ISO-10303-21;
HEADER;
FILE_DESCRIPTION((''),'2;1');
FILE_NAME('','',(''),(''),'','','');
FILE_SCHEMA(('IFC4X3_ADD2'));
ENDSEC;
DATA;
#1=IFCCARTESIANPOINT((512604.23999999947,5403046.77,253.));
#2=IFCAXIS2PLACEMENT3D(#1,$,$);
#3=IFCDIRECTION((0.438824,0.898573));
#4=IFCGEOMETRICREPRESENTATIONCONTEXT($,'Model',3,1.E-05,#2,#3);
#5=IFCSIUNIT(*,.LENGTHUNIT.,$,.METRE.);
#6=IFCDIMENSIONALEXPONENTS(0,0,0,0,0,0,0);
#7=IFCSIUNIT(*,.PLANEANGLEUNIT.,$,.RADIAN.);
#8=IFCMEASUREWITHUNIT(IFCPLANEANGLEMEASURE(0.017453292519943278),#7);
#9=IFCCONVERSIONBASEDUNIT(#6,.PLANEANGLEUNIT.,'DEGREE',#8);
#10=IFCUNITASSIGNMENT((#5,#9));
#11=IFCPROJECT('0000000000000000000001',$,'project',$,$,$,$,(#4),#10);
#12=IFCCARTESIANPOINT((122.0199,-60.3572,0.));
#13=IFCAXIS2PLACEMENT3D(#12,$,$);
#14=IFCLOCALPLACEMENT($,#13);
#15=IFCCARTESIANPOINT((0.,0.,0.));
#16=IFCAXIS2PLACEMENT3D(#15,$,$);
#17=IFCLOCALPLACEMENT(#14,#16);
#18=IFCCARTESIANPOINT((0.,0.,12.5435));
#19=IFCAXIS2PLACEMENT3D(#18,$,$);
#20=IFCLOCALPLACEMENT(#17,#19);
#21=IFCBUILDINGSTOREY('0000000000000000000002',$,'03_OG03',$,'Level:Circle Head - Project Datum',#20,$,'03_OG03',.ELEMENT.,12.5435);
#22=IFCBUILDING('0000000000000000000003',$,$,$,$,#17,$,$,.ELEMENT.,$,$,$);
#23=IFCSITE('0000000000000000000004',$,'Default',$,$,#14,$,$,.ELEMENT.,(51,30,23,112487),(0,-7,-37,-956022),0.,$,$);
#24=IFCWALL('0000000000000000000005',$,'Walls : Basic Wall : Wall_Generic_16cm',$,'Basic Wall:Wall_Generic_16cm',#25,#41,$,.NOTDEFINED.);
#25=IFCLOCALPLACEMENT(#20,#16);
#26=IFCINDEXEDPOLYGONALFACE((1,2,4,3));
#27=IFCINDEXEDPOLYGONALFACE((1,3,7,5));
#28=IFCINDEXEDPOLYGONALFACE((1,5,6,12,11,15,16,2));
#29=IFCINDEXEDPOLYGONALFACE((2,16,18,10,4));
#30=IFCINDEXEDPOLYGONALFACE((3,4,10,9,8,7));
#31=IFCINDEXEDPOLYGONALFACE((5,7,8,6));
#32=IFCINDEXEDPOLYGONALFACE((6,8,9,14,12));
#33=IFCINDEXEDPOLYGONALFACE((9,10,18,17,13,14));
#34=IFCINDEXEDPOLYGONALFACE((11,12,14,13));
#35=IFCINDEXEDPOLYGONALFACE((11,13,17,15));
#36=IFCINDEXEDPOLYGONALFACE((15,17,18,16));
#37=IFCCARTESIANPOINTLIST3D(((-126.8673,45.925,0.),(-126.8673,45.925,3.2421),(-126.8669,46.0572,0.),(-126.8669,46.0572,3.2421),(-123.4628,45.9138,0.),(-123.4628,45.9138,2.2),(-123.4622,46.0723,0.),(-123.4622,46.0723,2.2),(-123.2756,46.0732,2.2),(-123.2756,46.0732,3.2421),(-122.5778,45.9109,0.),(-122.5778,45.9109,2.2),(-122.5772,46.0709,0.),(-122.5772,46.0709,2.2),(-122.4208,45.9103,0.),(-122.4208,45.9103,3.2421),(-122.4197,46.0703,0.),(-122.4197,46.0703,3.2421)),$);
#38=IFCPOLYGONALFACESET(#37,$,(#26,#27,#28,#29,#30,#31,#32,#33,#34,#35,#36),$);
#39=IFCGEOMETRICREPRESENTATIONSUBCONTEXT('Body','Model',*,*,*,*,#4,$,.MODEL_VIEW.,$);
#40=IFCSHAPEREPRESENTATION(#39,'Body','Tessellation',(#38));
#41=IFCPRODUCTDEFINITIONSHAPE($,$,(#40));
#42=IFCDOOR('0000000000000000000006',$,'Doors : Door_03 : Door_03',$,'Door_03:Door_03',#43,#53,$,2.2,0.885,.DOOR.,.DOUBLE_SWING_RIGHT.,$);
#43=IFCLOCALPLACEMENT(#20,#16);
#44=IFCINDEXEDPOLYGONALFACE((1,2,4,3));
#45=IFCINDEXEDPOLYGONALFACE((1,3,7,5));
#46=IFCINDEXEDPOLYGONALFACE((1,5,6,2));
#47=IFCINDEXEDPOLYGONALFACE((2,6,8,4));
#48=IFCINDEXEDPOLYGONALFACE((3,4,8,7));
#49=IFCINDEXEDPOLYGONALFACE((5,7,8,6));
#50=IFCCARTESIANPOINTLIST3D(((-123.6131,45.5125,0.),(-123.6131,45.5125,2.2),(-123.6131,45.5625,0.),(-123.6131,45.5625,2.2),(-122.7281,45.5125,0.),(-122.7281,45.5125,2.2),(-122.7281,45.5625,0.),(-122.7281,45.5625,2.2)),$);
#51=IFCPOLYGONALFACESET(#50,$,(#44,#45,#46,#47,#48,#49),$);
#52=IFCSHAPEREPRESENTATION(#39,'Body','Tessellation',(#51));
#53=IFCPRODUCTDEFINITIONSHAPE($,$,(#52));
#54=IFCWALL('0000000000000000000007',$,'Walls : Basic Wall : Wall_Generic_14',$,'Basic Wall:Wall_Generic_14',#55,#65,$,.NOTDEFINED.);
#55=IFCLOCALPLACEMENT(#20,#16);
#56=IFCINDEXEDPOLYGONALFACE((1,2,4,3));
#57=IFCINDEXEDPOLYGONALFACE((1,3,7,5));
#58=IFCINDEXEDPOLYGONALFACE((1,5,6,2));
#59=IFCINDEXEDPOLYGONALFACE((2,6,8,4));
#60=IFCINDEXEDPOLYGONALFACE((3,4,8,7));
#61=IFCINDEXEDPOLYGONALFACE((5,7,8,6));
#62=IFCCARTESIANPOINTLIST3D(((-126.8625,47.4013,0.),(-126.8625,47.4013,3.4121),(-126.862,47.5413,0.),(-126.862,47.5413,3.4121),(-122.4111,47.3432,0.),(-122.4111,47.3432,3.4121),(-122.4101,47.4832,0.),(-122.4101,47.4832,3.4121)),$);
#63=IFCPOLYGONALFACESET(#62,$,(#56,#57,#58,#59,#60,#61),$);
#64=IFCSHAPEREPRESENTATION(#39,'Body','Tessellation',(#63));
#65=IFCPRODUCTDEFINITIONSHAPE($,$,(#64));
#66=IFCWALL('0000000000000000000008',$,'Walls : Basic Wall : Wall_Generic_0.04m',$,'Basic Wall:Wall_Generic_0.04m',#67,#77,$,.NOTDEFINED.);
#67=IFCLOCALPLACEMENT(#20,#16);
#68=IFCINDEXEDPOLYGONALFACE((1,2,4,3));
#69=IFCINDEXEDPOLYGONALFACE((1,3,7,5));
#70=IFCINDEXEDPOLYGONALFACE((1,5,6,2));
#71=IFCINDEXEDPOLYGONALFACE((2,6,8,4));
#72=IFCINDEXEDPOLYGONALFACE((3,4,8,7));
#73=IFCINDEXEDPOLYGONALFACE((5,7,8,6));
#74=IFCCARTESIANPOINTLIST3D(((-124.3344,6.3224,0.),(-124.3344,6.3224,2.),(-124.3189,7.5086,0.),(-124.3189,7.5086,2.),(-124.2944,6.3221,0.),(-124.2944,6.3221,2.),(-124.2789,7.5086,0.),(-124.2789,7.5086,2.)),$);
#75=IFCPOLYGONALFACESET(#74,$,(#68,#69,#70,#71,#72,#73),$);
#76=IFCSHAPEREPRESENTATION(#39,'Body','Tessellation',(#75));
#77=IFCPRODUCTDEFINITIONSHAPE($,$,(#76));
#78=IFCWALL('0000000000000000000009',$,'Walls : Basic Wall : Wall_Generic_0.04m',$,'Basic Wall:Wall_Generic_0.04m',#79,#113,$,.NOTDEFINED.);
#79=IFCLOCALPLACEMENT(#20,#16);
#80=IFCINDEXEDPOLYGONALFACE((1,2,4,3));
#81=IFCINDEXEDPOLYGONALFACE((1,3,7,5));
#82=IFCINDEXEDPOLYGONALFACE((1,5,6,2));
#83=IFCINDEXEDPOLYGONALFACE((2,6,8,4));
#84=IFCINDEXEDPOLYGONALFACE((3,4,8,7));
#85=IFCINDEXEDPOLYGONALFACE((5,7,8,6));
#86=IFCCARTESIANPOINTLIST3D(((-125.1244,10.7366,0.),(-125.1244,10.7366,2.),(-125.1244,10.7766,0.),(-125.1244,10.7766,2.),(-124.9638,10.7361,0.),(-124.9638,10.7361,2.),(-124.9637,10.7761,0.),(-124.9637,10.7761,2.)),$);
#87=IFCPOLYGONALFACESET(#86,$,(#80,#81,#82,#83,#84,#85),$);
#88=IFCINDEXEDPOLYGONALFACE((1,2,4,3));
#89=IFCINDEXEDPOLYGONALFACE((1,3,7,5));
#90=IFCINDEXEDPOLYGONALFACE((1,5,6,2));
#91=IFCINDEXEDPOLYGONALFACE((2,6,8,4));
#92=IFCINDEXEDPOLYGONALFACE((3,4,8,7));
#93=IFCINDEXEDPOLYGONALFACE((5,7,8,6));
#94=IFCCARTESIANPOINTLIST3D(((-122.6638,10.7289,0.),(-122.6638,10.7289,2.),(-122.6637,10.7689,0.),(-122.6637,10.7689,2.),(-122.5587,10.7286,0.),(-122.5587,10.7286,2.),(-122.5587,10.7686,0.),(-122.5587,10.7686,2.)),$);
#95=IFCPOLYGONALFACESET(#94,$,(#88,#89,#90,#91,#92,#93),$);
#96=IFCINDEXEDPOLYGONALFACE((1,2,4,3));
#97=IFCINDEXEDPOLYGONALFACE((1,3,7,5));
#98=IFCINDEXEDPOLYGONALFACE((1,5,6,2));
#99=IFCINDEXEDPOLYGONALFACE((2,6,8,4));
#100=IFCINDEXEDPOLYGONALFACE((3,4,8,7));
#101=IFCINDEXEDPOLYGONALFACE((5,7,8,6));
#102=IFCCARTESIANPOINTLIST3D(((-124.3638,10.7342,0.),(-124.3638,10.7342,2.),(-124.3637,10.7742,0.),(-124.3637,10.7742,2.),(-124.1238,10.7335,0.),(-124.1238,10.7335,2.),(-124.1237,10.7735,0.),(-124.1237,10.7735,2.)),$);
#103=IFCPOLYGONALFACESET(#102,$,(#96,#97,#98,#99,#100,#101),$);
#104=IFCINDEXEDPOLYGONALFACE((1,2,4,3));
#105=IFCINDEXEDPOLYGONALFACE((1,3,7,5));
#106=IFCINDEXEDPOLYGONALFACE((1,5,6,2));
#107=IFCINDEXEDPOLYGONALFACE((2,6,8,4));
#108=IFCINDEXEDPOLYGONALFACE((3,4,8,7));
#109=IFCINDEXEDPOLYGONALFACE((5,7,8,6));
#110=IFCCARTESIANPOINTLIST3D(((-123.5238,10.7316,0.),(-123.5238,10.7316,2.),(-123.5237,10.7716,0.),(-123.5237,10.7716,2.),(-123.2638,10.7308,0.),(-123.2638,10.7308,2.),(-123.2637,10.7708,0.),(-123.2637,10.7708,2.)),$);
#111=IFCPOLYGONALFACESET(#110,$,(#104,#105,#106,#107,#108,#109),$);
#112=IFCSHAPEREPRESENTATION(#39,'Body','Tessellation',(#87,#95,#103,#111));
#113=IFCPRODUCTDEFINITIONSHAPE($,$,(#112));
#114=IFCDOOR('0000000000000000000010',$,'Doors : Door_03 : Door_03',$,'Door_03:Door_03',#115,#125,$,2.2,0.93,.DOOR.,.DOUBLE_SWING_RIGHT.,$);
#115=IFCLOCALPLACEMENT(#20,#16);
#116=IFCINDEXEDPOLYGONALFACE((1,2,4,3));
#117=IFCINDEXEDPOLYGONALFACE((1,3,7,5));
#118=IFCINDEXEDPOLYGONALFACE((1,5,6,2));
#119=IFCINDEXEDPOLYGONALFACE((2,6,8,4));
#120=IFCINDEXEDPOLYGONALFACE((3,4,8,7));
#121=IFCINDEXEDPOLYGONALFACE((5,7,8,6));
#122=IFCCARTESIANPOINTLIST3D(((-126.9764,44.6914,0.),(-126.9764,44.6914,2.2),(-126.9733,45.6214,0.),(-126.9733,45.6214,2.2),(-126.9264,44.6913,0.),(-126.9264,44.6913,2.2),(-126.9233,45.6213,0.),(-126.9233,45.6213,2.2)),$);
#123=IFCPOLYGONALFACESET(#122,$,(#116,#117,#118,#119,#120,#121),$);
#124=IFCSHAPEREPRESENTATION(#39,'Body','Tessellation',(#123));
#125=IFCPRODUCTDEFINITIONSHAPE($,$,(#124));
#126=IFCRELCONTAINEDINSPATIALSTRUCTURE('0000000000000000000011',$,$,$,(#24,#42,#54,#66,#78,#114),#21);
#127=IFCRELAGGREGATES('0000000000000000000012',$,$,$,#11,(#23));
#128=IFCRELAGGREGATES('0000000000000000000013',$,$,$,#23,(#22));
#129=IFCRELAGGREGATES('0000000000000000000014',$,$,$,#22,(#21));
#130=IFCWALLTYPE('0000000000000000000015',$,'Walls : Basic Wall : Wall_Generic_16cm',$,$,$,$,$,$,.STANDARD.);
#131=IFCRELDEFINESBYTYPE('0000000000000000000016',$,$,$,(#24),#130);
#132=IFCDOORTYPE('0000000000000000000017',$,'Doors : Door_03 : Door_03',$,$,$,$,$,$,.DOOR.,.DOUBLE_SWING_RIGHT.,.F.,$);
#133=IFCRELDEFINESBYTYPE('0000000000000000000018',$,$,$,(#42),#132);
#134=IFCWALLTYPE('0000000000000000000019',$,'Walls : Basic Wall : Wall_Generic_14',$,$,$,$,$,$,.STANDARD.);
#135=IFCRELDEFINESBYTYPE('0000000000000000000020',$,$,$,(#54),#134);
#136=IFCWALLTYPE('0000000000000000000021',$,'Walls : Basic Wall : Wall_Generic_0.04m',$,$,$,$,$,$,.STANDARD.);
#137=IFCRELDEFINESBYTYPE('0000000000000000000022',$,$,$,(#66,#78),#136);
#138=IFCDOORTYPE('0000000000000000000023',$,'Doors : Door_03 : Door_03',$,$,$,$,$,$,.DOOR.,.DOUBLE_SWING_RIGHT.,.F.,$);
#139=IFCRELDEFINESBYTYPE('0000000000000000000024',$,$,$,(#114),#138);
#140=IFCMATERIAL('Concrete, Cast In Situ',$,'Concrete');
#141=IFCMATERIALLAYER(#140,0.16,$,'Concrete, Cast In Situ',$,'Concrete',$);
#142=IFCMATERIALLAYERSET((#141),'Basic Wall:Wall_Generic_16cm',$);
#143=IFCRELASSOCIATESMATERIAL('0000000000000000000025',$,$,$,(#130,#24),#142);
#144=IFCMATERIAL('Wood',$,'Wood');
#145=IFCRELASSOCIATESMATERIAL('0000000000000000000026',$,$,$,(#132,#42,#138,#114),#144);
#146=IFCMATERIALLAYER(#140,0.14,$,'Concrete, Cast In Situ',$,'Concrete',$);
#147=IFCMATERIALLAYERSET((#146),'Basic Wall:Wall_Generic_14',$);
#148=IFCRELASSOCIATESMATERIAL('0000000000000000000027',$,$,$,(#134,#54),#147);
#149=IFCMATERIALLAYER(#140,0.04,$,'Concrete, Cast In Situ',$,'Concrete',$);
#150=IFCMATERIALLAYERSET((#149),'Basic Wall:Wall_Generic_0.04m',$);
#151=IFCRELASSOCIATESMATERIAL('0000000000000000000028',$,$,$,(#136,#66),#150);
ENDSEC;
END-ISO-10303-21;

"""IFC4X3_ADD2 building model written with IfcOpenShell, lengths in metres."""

from ifc_helpers import new_model, entity, si_unit, converted_unit, direction, frame, frame_2d, origin, place, context, subcontext, project, spatial, polyline, rectangle, outline, extrude, clip, bounded_halfspace, source, transform, mapped, material, layer, layer_set, type_object, type_shapes, element, fill, save


model = new_model("IFC4X3_ADD2")

# Units and contexts
model_context = context("Model", 3, precision=1e-05, world=frame((512604.23999999947, 5403046.77, 253.0)), true_north=direction((0.438824, 0.898573)))
body_context = subcontext(model_context, "Body", "Model", "MODEL_VIEW")
ifc_project = project(units=[si_unit("LENGTHUNIT", "METRE"), converted_unit("PLANEANGLEUNIT", "DEGREE", entity("IfcPlaneAngleMeasure", 0.017453292519943278), si_unit("PLANEANGLEUNIT", "RADIAN"), dimensions=[0, 0, 0, 0, 0, 0, 0])], contexts=[model_context])

# Site, building, storey
site_placement = place(None, frame((122.0199, -60.3572, 0.0)))
site = spatial("IfcSite", under=ifc_project, at=site_placement, Name="Default", CompositionType="ELEMENT", RefLatitude=(51, 30, 23, 112487), RefLongitude=(0, -7, -37, -956022), RefElevation=0.0)
building_placement = place(site_placement, origin())
building = spatial("IfcBuilding", under=site, at=building_placement, CompositionType="ELEMENT")
storey_placement = place(building_placement, frame((0.0, 0.0, 12.5435)))
storey = spatial("IfcBuildingStorey", under=building, at=storey_placement, Name="03_OG03", ObjectType="Level:Circle Head - Project Datum", LongName="03_OG03", CompositionType="ELEMENT", Elevation=12.5435)

# Shared definitions
ifc_material_1 = material(Name="Concrete, Cast In Situ", Category="Concrete")

# Shared definitions
ifc_layer_1 = layer(ifc_material_1, 0.16, Name="Concrete, Cast In Situ", Category="Concrete")
ifc_layer_set_1 = layer_set([ifc_layer_1], Name="Basic Wall:Wall_Generic_16cm")
wall_type_1 = type_object("IfcWallType", Name="Walls : Basic Wall : Wall_Generic_16cm", PredefinedType="STANDARD", material=ifc_layer_set_1)
ifc_material_2 = material(Name="Wood", Category="Wood")

# Wall, opening, door
wall_1_placement = place(storey_placement, frame((-126.8671, 46.005, 0.0), z_axis=(0.0, 0.0, 1.0), x_axis=(0.999995, -0.003294, 0.0)))
wall_1 = element("IfcWall", 1, at=wall_1_placement, inside=storey, type_object=wall_type_1, material=ifc_layer_set_1, Name="Walls : Basic Wall : Wall_Generic_16cm", ObjectType="Basic Wall:Wall_Generic_16cm", PredefinedType="NOTDEFINED", context=body_context, shape_type="Clipping", body=[
    clip(extrude(outline(polyline([(0.0, -0.08), (4.4465, -0.08), (4.4471, 0.08), (3.5912, 0.08), (3.0949, 0.0762), (0.0, 0.0522), (0.0, -0.08)])), origin(), (0.0, 0.0, 1.0), 3.4121), bounded_halfspace(frame((0.0, -0.08, 3.2421), z_axis=(0.0, 0.0, -1.0), x_axis=(0.000456, -1.0, 0.0)), True, frame((0.0, -0.08, 3.2421)), polyline([(0.0, 0.0), (4.4465, 0.0), (4.4471, 0.16), (3.5912, 0.16), (3.0949, 0.1562), (0.0, 0.1322), (0.0, 0.0)]))),
])
opening_1_placement = place(wall_1_placement, frame((127.0179, -45.5869, 0.0), z_axis=(0.0, 0.0, 1.0), x_axis=(0.999995, 0.003294, 0.0)))
opening_1 = element("IfcOpeningElement", 2, at=opening_1_placement, cuts=wall_1, PredefinedType="OPENING", context=body_context, shape_type="SweptSolid", body=[
    extrude(rectangle(XDim=2.2, YDim=0.885, at=frame_2d((0.0, 0.0), x_axis=(0.0, 1.0))), frame((-123.0203, 45.9123, 1.1), z_axis=(0.003294, 0.999995, 0.0), x_axis=(0.999995, -0.003294, 0.0)), (0.0, 0.0, 1.0), 0.16),
])
door_type_1 = type_object("IfcDoorType", Name="Doors : Door_03 : Door_03", OperationType="DOUBLE_SWING_RIGHT", ParameterTakesPrecedence=False, PredefinedType="DOOR", material=ifc_material_2)
shared_shape_1 = source(origin(), body_context, "Body", "SweptSolid", [
    extrude(rectangle(XDim=0.05, YDim=0.885, at=frame_2d((0.0, 0.0), x_axis=(1.0, 0.0))), frame((0.4425, -0.1182, 0.0), z_axis=(0.0, 0.0, 1.0), x_axis=(0.0, 1.0, 0.0)), (0.0, 0.0, 1.0), 2.2),
])
type_shapes(door_type_1, [shared_shape_1])
door_1_placement = place(opening_1_placement, frame((-123.6131, 45.6557, 0.0)))
door_1 = element("IfcDoor", 3, at=door_1_placement, inside=storey, type_object=door_type_1, material=ifc_material_2, Name="Doors : Door_03 : Door_03", ObjectType="Door_03:Door_03", OperationType="DOUBLE_SWING_RIGHT", OverallHeight=2.2, OverallWidth=0.885, PredefinedType="DOOR", context=body_context, shape_type="MappedRepresentation", body=[
    mapped(shared_shape_1, transform((0.0, 0.0, 0.0), scale=1.0)),
])
fill(opening_1, door_1)

# Walls
ifc_layer_2 = layer(ifc_material_1, 0.14, Name="Concrete, Cast In Situ", Category="Concrete")
ifc_layer_set_2 = layer_set([ifc_layer_2], Name="Basic Wall:Wall_Generic_14")
wall_type_2 = type_object("IfcWallType", Name="Walls : Basic Wall : Wall_Generic_14", PredefinedType="STANDARD", material=ifc_layer_set_2)
wall_2_placement = place(storey_placement, frame((-126.8629, 47.4713, 0.0), z_axis=(0.0, 0.0, 1.0), x_axis=(0.999915, -0.013046, 0.0)))
element("IfcWall", 4, at=wall_2_placement, inside=storey, type_object=wall_type_2, material=ifc_layer_set_2, Name="Walls : Basic Wall : Wall_Generic_14", ObjectType="Basic Wall:Wall_Generic_14", PredefinedType="NOTDEFINED", context=body_context, shape_type="SweptSolid", body=[
    extrude(outline(polyline([(4.4532, -0.07), (4.4523, 0.07), (0.0, 0.07), (0.0014, -0.07), (4.4532, -0.07)])), origin(), (0.0, 0.0, 1.0), 3.4121),
])
ifc_layer_3 = layer(ifc_material_1, 0.04, Name="Concrete, Cast In Situ", Category="Concrete")
ifc_layer_set_3 = layer_set([ifc_layer_3], Name="Basic Wall:Wall_Generic_0.04m")
wall_type_3 = type_object("IfcWallType", Name="Walls : Basic Wall : Wall_Generic_0.04m", PredefinedType="STANDARD", material=ifc_layer_set_3)
wall_3_placement = place(storey_placement, frame((-124.3144, 6.3221, 0.0), z_axis=(0.0, 0.0, 1.0), x_axis=(0.01311, 0.999914, 0.0)))
element("IfcWall", 5, at=wall_3_placement, inside=storey, type_object=wall_type_3, material=ifc_layer_set_3, Name="Walls : Basic Wall : Wall_Generic_0.04m", ObjectType="Basic Wall:Wall_Generic_0.04m", PredefinedType="NOTDEFINED", context=body_context, shape_type="SweptSolid", body=[
    extrude(outline(polyline([(1.1868, -0.02), (1.1863, 0.02), (0.0, 0.02), (0.0003, -0.02), (1.1868, -0.02)])), origin(), (0.0, 0.0, 1.0), 2.0),
])
wall_4_placement = place(storey_placement, frame((-125.1245, 10.7566, 0.0), z_axis=(0.0, 0.0, 1.0), x_axis=(0.999995, -0.00314, 0.0)))
element("IfcWall", 6, at=wall_4_placement, inside=storey, type_object=wall_type_3, Name="Walls : Basic Wall : Wall_Generic_0.04m", ObjectType="Basic Wall:Wall_Generic_0.04m", PredefinedType="NOTDEFINED", context=body_context, shape_type="SweptSolid", body=[
    extrude(outline(polyline([(-0.0803, -0.02), (0.0803, -0.02), (0.0803, 0.02), (-0.0804, 0.02), (-0.0803, -0.02)])), frame((0.0804, 0.0, 0.0)), (0.0, 0.0, 1.0), 2.0),
    extrude(outline(polyline([(-0.0525, -0.02), (0.0525, -0.02), (0.0525, 0.02), (-0.0526, 0.02), (-0.0525, -0.02)])), frame((2.5133, 0.0, 0.0), z_axis=(0.0, 0.0, 1.0), x_axis=(-1.0, 0.0, 0.0)), (0.0, 0.0, 1.0), 2.0),
    extrude(rectangle(XDim=0.24, YDim=0.04, at=frame_2d((-0.0024, 0.0086), x_axis=(1.0, 0.0))), frame((0.8832, -0.0086, 0.0)), (0.0, 0.0, 1.0), 2.0),
    extrude(rectangle(XDim=0.26, YDim=0.04, at=frame_2d((-0.0094, 0.0086), x_axis=(1.0, 0.0))), frame((1.7401, -0.0086, 0.0)), (0.0, 0.0, 1.0), 2.0),
])

# Door
door_type_2 = type_object("IfcDoorType", Name="Doors : Door_03 : Door_03", OperationType="DOUBLE_SWING_RIGHT", ParameterTakesPrecedence=False, PredefinedType="DOOR", material=ifc_material_2)
shared_shape_2 = source(origin(), body_context, "Body", "SweptSolid", [
    extrude(rectangle(XDim=0.05, YDim=0.93, at=frame_2d((0.0, 0.0), x_axis=(1.0, 0.0))), frame((0.465, 0.08, 0.0), z_axis=(0.0, 0.0, 1.0), x_axis=(0.0, 1.0, 0.0)), (0.0, 0.0, 1.0), 2.2),
])
type_shapes(door_type_2, [shared_shape_2])
door_2_placement = place(storey_placement, frame((-126.8714, 44.6911, 0.0), z_axis=(0.0, 0.0, 1.0), x_axis=(0.003272, 0.999995, 0.0)))
element("IfcDoor", 7, at=door_2_placement, inside=storey, type_object=door_type_2, material=ifc_material_2, Name="Doors : Door_03 : Door_03", ObjectType="Door_03:Door_03", OperationType="DOUBLE_SWING_RIGHT", OverallHeight=2.2, OverallWidth=0.93, PredefinedType="DOOR", context=body_context, shape_type="MappedRepresentation", body=[
    mapped(shared_shape_2, transform((0.0, 0.0, 0.0), scale=1.0)),
])

save(model, "model.ifc")
